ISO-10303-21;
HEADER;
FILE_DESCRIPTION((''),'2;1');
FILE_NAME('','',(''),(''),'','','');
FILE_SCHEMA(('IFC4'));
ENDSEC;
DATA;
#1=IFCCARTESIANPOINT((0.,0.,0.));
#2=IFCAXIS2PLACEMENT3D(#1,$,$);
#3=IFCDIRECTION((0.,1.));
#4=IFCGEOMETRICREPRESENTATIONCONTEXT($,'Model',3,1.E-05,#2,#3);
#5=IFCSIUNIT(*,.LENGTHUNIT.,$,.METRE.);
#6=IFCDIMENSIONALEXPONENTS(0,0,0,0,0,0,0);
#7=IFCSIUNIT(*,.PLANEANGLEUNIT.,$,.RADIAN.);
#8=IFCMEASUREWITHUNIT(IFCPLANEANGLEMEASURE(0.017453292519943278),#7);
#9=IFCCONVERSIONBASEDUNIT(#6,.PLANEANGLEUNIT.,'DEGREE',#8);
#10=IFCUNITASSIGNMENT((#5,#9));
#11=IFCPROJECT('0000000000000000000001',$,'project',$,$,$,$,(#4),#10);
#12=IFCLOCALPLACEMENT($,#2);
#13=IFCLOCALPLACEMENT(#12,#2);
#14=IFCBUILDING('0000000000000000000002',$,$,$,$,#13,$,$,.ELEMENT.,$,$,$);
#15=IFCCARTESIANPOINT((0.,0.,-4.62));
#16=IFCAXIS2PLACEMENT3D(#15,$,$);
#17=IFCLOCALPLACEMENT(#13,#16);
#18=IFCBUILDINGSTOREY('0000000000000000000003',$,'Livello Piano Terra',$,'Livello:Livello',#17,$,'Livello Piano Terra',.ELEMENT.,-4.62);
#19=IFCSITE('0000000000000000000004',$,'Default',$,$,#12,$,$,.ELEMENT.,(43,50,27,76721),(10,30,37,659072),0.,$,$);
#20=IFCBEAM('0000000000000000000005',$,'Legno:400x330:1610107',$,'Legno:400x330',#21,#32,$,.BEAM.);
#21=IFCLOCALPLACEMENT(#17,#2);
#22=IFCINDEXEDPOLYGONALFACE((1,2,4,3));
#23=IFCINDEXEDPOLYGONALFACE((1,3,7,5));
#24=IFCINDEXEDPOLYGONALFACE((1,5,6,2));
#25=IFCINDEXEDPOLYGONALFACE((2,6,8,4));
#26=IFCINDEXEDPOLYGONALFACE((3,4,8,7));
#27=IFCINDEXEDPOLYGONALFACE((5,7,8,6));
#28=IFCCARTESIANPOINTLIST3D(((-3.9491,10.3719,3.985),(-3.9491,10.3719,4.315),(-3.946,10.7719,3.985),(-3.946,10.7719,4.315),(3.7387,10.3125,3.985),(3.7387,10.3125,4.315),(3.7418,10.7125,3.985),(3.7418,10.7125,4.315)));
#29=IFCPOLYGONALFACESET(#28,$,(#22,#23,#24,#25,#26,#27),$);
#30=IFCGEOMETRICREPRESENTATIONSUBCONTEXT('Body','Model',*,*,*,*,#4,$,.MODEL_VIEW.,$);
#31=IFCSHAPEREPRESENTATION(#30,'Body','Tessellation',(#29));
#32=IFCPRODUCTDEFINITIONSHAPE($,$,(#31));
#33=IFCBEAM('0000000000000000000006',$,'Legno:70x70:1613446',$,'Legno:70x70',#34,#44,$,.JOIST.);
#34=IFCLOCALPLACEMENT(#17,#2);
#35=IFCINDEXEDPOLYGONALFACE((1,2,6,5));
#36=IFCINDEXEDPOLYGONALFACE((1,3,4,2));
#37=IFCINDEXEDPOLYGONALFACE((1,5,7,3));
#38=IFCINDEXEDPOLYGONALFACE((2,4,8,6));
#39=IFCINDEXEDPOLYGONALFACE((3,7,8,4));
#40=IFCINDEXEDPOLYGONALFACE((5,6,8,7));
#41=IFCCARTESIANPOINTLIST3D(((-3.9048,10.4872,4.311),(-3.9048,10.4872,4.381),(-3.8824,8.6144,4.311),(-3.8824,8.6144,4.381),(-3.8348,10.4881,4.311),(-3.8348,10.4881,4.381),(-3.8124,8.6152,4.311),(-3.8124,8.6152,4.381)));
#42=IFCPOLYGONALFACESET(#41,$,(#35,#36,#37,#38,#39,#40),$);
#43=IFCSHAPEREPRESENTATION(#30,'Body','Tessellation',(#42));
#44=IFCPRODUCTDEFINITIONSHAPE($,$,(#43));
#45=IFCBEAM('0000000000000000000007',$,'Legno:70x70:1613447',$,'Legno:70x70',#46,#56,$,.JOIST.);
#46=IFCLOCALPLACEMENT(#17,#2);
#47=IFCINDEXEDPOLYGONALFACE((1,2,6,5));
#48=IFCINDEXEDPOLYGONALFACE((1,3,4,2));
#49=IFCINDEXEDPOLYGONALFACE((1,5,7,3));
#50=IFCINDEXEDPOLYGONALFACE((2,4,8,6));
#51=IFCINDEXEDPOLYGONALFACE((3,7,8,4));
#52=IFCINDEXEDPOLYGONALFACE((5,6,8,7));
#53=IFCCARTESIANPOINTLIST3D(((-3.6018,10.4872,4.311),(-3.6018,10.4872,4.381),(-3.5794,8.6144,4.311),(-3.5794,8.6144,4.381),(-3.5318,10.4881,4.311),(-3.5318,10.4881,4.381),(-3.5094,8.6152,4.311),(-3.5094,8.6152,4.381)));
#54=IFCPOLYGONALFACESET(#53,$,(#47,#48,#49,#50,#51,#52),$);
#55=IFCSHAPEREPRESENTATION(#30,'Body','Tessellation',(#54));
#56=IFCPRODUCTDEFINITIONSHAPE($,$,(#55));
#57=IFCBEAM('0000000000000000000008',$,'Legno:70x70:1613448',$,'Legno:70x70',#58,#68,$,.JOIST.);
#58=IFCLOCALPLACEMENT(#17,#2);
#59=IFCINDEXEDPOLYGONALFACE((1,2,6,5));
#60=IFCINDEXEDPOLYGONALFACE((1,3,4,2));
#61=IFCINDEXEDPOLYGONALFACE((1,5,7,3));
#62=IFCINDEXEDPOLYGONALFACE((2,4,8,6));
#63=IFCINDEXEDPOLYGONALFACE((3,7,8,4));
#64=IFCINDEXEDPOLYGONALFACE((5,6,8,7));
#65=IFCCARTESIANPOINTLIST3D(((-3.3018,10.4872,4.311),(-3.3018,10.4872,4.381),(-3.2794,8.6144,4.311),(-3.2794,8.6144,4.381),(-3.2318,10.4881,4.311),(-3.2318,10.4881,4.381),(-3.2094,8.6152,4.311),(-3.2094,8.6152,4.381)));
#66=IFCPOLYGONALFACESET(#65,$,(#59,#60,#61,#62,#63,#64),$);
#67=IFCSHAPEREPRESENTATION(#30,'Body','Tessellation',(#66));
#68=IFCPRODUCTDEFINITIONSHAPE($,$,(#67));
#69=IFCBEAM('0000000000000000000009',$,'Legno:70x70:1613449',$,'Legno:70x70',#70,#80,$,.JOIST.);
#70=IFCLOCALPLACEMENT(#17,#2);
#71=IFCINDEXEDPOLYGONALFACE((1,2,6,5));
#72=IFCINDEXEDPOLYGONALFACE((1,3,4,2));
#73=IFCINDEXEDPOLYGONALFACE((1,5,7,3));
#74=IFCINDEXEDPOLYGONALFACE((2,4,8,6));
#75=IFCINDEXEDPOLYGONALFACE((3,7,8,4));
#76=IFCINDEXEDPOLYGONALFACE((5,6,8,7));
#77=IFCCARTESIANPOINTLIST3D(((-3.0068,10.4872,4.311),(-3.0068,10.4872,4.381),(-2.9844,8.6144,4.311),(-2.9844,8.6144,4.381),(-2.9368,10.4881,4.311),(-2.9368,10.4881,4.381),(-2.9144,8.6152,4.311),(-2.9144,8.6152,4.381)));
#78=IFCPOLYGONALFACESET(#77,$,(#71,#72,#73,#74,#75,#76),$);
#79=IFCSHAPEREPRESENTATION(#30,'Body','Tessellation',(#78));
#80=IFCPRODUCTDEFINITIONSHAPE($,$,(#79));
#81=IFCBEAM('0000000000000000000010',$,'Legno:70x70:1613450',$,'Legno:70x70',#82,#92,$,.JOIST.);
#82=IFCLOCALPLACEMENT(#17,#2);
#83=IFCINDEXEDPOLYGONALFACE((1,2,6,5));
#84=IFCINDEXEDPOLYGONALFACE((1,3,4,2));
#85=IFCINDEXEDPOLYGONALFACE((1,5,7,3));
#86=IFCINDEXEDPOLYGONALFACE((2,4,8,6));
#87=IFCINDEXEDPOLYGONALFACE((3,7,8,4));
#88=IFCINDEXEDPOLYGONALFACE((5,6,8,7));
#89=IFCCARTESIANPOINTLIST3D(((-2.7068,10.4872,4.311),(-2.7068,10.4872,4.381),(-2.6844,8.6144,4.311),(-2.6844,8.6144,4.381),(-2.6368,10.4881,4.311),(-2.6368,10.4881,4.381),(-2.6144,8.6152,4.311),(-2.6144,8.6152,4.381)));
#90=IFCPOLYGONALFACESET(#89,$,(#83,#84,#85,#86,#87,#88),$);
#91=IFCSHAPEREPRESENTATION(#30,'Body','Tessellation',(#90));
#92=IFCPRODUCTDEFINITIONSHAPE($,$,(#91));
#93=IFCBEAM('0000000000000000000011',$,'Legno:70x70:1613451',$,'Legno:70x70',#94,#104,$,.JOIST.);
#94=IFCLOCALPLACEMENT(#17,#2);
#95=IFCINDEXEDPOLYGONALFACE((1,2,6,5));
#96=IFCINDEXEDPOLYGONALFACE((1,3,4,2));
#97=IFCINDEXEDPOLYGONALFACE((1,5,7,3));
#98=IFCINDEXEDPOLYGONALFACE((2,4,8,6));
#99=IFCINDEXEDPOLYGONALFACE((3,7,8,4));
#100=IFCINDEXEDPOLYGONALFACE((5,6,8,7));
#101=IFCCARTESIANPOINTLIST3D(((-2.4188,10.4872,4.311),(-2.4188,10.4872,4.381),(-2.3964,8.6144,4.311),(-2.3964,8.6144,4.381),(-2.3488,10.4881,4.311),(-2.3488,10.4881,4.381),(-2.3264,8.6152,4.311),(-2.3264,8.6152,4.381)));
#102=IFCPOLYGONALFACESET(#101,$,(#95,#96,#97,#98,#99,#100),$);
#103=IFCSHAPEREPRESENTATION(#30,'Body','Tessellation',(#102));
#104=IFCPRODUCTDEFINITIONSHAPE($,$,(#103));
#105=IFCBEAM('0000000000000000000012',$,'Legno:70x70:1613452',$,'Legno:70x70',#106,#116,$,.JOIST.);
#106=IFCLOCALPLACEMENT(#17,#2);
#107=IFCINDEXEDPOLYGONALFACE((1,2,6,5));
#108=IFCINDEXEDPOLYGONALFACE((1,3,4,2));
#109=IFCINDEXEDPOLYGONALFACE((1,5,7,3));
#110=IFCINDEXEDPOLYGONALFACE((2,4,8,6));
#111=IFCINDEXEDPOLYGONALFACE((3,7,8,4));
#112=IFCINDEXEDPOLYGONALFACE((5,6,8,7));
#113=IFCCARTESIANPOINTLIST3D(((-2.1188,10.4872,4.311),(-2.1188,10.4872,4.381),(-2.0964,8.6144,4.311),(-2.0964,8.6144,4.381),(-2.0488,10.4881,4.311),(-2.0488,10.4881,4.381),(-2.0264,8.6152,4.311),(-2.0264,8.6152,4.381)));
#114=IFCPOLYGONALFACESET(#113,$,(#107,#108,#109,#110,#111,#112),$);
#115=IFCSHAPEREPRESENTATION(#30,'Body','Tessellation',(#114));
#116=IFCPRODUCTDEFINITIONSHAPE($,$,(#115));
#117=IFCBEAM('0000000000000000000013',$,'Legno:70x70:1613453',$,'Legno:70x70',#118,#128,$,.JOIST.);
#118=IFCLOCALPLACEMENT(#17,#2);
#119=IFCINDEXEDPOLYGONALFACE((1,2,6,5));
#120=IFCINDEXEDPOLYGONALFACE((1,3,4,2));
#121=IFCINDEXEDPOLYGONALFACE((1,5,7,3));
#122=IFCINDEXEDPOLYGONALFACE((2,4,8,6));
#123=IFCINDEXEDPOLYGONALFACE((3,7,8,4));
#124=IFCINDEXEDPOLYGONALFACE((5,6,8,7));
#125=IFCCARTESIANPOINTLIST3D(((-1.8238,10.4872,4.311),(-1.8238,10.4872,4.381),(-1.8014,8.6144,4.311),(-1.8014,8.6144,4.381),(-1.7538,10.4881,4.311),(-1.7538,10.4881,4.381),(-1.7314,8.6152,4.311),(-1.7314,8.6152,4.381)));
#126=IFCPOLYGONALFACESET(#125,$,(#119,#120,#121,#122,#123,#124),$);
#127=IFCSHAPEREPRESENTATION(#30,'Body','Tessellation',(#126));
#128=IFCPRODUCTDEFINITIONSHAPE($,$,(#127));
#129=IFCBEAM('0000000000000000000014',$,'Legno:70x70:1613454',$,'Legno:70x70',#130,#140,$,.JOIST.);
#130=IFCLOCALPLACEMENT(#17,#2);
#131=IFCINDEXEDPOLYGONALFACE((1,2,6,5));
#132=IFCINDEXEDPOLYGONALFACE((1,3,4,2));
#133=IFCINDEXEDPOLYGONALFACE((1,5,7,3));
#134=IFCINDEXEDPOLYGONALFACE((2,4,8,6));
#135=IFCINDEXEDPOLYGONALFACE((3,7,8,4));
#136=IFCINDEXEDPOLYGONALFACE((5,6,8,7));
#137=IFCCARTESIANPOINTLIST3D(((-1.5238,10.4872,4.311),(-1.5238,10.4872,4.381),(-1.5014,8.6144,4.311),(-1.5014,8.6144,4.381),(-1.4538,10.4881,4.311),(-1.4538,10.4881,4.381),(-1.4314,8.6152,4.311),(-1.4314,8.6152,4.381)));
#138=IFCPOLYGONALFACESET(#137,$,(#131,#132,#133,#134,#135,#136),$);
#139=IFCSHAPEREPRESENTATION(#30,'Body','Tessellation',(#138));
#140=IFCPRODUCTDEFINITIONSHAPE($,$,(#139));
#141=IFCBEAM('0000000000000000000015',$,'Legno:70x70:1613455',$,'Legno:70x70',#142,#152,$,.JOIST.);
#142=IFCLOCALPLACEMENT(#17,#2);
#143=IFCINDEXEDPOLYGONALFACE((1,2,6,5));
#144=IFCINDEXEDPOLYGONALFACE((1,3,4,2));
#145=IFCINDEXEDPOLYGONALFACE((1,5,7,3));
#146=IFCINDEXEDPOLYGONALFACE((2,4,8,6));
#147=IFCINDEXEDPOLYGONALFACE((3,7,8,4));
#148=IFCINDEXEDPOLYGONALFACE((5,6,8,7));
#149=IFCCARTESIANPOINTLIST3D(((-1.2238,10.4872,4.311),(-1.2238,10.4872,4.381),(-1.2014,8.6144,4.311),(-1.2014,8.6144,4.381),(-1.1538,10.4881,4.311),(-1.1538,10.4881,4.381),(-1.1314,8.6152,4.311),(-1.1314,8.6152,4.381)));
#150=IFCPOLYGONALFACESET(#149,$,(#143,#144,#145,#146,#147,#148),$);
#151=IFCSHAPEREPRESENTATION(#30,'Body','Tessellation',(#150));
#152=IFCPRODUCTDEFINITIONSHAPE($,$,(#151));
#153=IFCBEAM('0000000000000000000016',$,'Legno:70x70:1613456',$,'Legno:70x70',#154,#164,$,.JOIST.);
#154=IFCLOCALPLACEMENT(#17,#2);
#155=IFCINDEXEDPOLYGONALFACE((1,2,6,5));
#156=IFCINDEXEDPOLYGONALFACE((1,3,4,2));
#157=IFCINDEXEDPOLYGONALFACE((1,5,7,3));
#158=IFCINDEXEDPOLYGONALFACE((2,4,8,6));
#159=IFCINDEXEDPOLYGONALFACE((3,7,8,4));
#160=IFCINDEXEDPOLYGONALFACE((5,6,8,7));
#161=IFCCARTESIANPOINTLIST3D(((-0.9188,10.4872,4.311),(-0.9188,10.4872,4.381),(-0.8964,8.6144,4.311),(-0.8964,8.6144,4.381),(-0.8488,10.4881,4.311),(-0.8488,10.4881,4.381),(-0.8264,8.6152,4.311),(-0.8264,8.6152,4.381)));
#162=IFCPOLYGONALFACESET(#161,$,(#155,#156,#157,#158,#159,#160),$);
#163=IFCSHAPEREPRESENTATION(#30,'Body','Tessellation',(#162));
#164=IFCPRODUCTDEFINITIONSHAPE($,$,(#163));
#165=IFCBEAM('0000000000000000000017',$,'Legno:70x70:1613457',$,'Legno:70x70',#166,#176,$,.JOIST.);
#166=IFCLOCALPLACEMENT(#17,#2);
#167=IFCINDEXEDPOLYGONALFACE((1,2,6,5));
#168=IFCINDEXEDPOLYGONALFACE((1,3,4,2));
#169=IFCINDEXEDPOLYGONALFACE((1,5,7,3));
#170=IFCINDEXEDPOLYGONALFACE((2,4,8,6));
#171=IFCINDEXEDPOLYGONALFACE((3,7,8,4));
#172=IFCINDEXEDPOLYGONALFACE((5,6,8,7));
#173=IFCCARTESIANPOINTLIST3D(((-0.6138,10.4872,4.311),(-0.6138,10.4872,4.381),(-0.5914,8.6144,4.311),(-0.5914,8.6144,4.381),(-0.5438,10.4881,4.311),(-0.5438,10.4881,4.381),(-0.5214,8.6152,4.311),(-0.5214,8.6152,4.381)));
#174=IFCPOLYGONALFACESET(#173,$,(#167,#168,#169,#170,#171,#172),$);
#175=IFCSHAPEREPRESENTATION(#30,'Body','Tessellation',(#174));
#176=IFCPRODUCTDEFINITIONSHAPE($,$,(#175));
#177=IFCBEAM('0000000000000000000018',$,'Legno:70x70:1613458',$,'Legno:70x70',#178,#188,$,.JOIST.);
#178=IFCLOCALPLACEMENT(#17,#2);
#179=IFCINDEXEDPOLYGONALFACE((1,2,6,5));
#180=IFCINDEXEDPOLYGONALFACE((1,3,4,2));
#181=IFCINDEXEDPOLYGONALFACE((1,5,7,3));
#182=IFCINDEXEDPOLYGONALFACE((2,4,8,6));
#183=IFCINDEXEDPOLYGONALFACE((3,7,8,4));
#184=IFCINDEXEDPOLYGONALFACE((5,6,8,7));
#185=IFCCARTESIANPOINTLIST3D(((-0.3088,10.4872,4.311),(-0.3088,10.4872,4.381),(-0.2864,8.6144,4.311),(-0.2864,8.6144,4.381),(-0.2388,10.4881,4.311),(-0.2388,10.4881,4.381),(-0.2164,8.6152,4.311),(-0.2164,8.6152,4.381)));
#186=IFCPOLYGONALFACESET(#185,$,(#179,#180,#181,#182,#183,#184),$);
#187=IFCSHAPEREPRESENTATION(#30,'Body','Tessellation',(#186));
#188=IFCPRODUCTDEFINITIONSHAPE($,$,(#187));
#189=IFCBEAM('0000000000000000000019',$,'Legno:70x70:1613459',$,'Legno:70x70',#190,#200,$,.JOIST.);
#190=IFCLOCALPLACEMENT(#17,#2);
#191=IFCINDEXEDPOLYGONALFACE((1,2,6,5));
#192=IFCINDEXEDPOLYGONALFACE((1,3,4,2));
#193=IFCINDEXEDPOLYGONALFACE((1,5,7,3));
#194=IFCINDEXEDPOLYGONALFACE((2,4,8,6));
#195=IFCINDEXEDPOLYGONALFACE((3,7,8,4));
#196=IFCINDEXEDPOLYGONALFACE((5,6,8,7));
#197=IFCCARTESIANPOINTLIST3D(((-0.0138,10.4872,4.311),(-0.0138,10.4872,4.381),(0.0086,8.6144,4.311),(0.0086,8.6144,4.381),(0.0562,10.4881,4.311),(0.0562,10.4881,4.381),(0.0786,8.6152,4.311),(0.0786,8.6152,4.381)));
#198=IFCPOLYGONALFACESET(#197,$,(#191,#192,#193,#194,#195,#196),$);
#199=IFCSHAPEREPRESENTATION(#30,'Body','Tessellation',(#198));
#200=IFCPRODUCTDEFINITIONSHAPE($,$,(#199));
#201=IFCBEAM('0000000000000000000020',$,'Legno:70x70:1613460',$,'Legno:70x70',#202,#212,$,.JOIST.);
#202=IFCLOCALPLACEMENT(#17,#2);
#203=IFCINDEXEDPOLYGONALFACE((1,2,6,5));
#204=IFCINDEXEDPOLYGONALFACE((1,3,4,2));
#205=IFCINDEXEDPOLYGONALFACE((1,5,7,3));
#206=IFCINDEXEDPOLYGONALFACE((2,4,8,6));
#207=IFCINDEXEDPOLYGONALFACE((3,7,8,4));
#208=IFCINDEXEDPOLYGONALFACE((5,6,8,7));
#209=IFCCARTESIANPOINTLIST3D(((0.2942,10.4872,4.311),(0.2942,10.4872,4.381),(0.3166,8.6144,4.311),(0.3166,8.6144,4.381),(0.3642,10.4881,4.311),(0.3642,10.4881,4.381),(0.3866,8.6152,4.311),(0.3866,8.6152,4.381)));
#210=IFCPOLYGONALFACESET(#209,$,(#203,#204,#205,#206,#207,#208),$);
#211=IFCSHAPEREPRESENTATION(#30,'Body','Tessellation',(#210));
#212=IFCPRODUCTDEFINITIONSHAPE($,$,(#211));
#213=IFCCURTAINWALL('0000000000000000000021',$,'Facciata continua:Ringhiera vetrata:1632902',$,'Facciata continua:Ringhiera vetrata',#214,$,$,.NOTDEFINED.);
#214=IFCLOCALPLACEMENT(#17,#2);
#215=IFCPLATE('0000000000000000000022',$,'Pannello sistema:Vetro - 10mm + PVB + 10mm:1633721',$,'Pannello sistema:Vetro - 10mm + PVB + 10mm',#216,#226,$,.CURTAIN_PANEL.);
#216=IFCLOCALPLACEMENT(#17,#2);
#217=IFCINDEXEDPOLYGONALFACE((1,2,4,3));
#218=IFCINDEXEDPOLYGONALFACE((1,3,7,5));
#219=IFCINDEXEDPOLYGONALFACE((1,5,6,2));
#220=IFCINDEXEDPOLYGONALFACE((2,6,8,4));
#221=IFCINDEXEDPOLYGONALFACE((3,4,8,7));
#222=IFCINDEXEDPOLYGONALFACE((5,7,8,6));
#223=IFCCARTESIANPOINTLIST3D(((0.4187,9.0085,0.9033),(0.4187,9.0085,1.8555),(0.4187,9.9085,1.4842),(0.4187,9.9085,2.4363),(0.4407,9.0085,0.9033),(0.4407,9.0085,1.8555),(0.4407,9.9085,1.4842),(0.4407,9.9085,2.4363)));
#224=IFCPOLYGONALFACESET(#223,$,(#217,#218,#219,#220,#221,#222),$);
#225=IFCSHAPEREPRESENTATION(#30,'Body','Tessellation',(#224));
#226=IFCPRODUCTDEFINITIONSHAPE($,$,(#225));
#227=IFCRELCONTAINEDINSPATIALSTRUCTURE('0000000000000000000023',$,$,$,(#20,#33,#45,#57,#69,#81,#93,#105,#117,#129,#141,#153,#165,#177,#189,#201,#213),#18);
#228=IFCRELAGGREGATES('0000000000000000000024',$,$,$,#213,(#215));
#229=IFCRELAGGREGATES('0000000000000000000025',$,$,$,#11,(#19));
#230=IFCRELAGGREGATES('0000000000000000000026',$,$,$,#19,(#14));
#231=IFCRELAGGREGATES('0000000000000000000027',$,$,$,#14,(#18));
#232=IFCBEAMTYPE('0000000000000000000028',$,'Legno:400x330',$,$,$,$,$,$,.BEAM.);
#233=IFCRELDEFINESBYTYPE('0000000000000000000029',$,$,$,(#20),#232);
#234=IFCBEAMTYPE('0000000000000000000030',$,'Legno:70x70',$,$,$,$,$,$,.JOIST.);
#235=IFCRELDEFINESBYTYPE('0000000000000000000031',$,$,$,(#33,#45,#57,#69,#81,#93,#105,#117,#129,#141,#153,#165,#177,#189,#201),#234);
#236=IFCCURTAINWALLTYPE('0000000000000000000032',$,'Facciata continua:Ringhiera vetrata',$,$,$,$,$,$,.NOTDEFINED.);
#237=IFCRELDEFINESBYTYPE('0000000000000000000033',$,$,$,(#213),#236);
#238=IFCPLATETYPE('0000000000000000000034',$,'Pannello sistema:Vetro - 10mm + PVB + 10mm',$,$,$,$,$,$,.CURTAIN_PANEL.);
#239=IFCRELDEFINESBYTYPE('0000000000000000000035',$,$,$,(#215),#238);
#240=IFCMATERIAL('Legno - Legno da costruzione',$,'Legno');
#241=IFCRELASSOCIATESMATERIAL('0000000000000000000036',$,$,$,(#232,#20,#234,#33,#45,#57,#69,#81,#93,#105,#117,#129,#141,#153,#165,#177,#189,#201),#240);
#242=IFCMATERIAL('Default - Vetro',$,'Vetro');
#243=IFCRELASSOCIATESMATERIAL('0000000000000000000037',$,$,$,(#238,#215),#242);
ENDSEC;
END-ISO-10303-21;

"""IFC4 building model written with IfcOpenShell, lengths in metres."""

from ifc_helpers import new_model, entity, si_unit, converted_unit, direction, frame, origin, place, context, subcontext, project, spatial, indexed_curve, outline, extrude, source, transform, mapped, material, type_object, type_shapes, element, aggregate, save


model = new_model("IFC4")

# Units and contexts
model_context = context("Model", 3, precision=1e-05, world=origin(), true_north=direction((0.0, 1.0)))
body_context = subcontext(model_context, "Body", "Model", "MODEL_VIEW")
ifc_project = project(units=[si_unit("LENGTHUNIT", "METRE"), converted_unit("PLANEANGLEUNIT", "DEGREE", entity("IfcPlaneAngleMeasure", 0.017453292519943278), si_unit("PLANEANGLEUNIT", "RADIAN"), dimensions=[0, 0, 0, 0, 0, 0, 0])], contexts=[model_context])

# Site, building, storey
site_placement = place(None, origin())
site = spatial("IfcSite", under=ifc_project, at=site_placement, Name="Default", CompositionType="ELEMENT", RefLatitude=(43, 50, 27, 76721), RefLongitude=(10, 30, 37, 659072), RefElevation=0.0)
building_placement = place(site_placement, origin())
building = spatial("IfcBuilding", under=site, at=building_placement, CompositionType="ELEMENT")
storey_placement = place(building_placement, frame((0.0, 0.0, -4.62)))
storey = spatial("IfcBuildingStorey", under=building, at=storey_placement, Name="Livello Piano Terra", ObjectType="Livello:Livello", LongName="Livello Piano Terra", CompositionType="ELEMENT", Elevation=-4.62)

# Beams
ifc_material_1 = material(Name="Legno - Legno da costruzione", Category="Legno")
beam_type_1 = type_object("IfcBeamType", Name="Legno:400x330", PredefinedType="BEAM", material=ifc_material_1)
shared_shape_1 = source(origin(), body_context, "Body", "SweptSolid", [
    extrude(outline(indexed_curve([(-3.844, -0.2), (3.844, -0.2), (3.844, 0.2), (-3.844, 0.2), (-3.844, -0.2)], self_intersect=False)), frame((0.0, 0.0, -0.165), z_axis=(0.0, 0.0, 1.0), x_axis=(-1.0, 0.0, 0.0)), (0.0, 0.0, 1.0), 0.33),
])
type_shapes(beam_type_1, [shared_shape_1])
beam_1_placement = place(storey_placement, frame((-0.1037, 10.5422, 4.15), z_axis=(0.0, 0.0, 1.0), x_axis=(0.99997, -0.007726, 0.0)))
element("IfcBeam", 1, at=beam_1_placement, inside=storey, type_object=beam_type_1, material=ifc_material_1, Name="Legno:400x330:1610107", ObjectType="Legno:400x330", PredefinedType="BEAM", context=body_context, shape_type="MappedRepresentation", body=[
    mapped(shared_shape_1, transform((0.0, 0.0, 0.0), scale=1.0)),
])
beam_type_2 = type_object("IfcBeamType", Name="Legno:70x70", PredefinedType="JOIST", material=ifc_material_1)
shared_shape_2 = source(origin(), body_context, "Body", "SweptSolid", [
    extrude(outline(indexed_curve([(-0.9365, -0.035), (0.9365, -0.035), (0.9365, 0.035), (-0.9365, 0.035), (-0.9365, -0.035)], self_intersect=False)), frame((0.05, 0.0, -0.035), z_axis=(0.0, 0.0, 1.0), x_axis=(-1.0, 0.0, 0.0)), (0.0, 0.0, 1.0), 0.07),
])
type_shapes(beam_type_2, [shared_shape_2])
for number, where, z_axis, x_axis, name in (
    (2, (-3.8592, 9.6012, 4.346), (0.0, 0.0, 1.0), (0.011914, -0.999929, 0.0), "Legno:70x70:1613446"),
    (3, (-3.5562, 9.6012, 4.346), (0.0, 0.0, 1.0), (0.011914, -0.999929, 0.0), "Legno:70x70:1613447"),
    (4, (-3.2562, 9.6012, 4.346), (0.0, 0.0, 1.0), (0.011914, -0.999929, 0.0), "Legno:70x70:1613448"),
    (5, (-2.9612, 9.6012, 4.346), (0.0, 0.0, 1.0), (0.011914, -0.999929, 0.0), "Legno:70x70:1613449"),
    (6, (-2.6612, 9.6012, 4.346), (0.0, 0.0, 1.0), (0.011914, -0.999929, 0.0), "Legno:70x70:1613450"),
    (7, (-2.3732, 9.6012, 4.346), (0.0, 0.0, 1.0), (0.011914, -0.999929, 0.0), "Legno:70x70:1613451"),
    (8, (-2.0732, 9.6012, 4.346), (0.0, 0.0, 1.0), (0.011914, -0.999929, 0.0), "Legno:70x70:1613452"),
    (9, (-1.7782, 9.6012, 4.346), (0.0, 0.0, 1.0), (0.011914, -0.999929, 0.0), "Legno:70x70:1613453"),
    (10, (-1.4782, 9.6012, 4.346), (0.0, 0.0, 1.0), (0.011914, -0.999929, 0.0), "Legno:70x70:1613454"),
    (11, (-1.1782, 9.6012, 4.346), (0.0, 0.0, 1.0), (0.011914, -0.999929, 0.0), "Legno:70x70:1613455"),
    (12, (-0.8732, 9.6012, 4.346), (0.0, 0.0, 1.0), (0.011914, -0.999929, 0.0), "Legno:70x70:1613456"),
    (13, (-0.5682, 9.6012, 4.346), (0.0, 0.0, 1.0), (0.011914, -0.999929, 0.0), "Legno:70x70:1613457"),
    (14, (-0.2632, 9.6012, 4.346), (0.0, 0.0, 1.0), (0.011914, -0.999929, 0.0), "Legno:70x70:1613458"),
    (15, (0.0318, 9.6012, 4.346), (0.0, 0.0, 1.0), (0.011914, -0.999929, 0.0), "Legno:70x70:1613459"),
    (16, (0.3398, 9.6012, 4.346), (0.0, 0.0, 1.0), (0.011914, -0.999929, 0.0), "Legno:70x70:1613460"),
):
    element("IfcBeam", number, at=place(storey_placement, frame(where, z_axis=z_axis, x_axis=x_axis)), inside=storey, type_object=beam_type_2, material=ifc_material_1, Name=name, ObjectType="Legno:70x70", PredefinedType="JOIST", context=body_context, shape_type="MappedRepresentation", body=[
        mapped(shared_shape_2, transform((0.0, 0.0, 0.0), scale=1.0)),
    ])

# Curtain wall, plate
curtain_wall_type = type_object("IfcCurtainWallType", Name="Facciata continua:Ringhiera vetrata", PredefinedType="NOTDEFINED")
curtain_wall_placement = place(storey_placement, frame((0.0, 0.0, 4.62)))
curtain_wall = element("IfcCurtainWall", 17, at=curtain_wall_placement, inside=storey, type_object=curtain_wall_type, Name="Facciata continua:Ringhiera vetrata:1632902", ObjectType="Facciata continua:Ringhiera vetrata", PredefinedType="NOTDEFINED")
ifc_material_2 = material(Name="Default - Vetro", Category="Vetro")
plate_type = type_object("IfcPlateType", Name="Pannello sistema:Vetro - 10mm + PVB + 10mm", PredefinedType="CURTAIN_PANEL", material=ifc_material_2)
shared_shape_3 = source(origin(), body_context, "Body", "SweptSolid", [
    extrude(outline(indexed_curve([(-0.7665, -0.45), (0.1856, -0.45), (0.7665, 0.45), (-0.1856, 0.45), (-0.7665, -0.45)], self_intersect=False)), frame((0.0, -0.011, 0.7665), z_axis=(0.0, 1.0, 0.0), x_axis=(0.0, 0.0, 1.0)), (0.0, 0.0, 1.0), 0.022),
])
type_shapes(plate_type, [shared_shape_3])
plate_1_placement = place(curtain_wall_placement, frame((0.4297, 9.4585, -3.7167), z_axis=(0.0, 0.0, 1.0), x_axis=(0.0, 1.0, 0.0)))
plate_1 = element("IfcPlate", 18, at=plate_1_placement, type_object=plate_type, material=ifc_material_2, Name="Pannello sistema:Vetro - 10mm + PVB + 10mm:1633721", ObjectType="Pannello sistema:Vetro - 10mm + PVB + 10mm", PredefinedType="CURTAIN_PANEL", context=body_context, shape_type="MappedRepresentation", body=[
    mapped(shared_shape_3, transform((0.0, 0.0, 0.0), scale=1.0)),
])
aggregate(curtain_wall, [plate_1])

save(model, "model.ifc")
